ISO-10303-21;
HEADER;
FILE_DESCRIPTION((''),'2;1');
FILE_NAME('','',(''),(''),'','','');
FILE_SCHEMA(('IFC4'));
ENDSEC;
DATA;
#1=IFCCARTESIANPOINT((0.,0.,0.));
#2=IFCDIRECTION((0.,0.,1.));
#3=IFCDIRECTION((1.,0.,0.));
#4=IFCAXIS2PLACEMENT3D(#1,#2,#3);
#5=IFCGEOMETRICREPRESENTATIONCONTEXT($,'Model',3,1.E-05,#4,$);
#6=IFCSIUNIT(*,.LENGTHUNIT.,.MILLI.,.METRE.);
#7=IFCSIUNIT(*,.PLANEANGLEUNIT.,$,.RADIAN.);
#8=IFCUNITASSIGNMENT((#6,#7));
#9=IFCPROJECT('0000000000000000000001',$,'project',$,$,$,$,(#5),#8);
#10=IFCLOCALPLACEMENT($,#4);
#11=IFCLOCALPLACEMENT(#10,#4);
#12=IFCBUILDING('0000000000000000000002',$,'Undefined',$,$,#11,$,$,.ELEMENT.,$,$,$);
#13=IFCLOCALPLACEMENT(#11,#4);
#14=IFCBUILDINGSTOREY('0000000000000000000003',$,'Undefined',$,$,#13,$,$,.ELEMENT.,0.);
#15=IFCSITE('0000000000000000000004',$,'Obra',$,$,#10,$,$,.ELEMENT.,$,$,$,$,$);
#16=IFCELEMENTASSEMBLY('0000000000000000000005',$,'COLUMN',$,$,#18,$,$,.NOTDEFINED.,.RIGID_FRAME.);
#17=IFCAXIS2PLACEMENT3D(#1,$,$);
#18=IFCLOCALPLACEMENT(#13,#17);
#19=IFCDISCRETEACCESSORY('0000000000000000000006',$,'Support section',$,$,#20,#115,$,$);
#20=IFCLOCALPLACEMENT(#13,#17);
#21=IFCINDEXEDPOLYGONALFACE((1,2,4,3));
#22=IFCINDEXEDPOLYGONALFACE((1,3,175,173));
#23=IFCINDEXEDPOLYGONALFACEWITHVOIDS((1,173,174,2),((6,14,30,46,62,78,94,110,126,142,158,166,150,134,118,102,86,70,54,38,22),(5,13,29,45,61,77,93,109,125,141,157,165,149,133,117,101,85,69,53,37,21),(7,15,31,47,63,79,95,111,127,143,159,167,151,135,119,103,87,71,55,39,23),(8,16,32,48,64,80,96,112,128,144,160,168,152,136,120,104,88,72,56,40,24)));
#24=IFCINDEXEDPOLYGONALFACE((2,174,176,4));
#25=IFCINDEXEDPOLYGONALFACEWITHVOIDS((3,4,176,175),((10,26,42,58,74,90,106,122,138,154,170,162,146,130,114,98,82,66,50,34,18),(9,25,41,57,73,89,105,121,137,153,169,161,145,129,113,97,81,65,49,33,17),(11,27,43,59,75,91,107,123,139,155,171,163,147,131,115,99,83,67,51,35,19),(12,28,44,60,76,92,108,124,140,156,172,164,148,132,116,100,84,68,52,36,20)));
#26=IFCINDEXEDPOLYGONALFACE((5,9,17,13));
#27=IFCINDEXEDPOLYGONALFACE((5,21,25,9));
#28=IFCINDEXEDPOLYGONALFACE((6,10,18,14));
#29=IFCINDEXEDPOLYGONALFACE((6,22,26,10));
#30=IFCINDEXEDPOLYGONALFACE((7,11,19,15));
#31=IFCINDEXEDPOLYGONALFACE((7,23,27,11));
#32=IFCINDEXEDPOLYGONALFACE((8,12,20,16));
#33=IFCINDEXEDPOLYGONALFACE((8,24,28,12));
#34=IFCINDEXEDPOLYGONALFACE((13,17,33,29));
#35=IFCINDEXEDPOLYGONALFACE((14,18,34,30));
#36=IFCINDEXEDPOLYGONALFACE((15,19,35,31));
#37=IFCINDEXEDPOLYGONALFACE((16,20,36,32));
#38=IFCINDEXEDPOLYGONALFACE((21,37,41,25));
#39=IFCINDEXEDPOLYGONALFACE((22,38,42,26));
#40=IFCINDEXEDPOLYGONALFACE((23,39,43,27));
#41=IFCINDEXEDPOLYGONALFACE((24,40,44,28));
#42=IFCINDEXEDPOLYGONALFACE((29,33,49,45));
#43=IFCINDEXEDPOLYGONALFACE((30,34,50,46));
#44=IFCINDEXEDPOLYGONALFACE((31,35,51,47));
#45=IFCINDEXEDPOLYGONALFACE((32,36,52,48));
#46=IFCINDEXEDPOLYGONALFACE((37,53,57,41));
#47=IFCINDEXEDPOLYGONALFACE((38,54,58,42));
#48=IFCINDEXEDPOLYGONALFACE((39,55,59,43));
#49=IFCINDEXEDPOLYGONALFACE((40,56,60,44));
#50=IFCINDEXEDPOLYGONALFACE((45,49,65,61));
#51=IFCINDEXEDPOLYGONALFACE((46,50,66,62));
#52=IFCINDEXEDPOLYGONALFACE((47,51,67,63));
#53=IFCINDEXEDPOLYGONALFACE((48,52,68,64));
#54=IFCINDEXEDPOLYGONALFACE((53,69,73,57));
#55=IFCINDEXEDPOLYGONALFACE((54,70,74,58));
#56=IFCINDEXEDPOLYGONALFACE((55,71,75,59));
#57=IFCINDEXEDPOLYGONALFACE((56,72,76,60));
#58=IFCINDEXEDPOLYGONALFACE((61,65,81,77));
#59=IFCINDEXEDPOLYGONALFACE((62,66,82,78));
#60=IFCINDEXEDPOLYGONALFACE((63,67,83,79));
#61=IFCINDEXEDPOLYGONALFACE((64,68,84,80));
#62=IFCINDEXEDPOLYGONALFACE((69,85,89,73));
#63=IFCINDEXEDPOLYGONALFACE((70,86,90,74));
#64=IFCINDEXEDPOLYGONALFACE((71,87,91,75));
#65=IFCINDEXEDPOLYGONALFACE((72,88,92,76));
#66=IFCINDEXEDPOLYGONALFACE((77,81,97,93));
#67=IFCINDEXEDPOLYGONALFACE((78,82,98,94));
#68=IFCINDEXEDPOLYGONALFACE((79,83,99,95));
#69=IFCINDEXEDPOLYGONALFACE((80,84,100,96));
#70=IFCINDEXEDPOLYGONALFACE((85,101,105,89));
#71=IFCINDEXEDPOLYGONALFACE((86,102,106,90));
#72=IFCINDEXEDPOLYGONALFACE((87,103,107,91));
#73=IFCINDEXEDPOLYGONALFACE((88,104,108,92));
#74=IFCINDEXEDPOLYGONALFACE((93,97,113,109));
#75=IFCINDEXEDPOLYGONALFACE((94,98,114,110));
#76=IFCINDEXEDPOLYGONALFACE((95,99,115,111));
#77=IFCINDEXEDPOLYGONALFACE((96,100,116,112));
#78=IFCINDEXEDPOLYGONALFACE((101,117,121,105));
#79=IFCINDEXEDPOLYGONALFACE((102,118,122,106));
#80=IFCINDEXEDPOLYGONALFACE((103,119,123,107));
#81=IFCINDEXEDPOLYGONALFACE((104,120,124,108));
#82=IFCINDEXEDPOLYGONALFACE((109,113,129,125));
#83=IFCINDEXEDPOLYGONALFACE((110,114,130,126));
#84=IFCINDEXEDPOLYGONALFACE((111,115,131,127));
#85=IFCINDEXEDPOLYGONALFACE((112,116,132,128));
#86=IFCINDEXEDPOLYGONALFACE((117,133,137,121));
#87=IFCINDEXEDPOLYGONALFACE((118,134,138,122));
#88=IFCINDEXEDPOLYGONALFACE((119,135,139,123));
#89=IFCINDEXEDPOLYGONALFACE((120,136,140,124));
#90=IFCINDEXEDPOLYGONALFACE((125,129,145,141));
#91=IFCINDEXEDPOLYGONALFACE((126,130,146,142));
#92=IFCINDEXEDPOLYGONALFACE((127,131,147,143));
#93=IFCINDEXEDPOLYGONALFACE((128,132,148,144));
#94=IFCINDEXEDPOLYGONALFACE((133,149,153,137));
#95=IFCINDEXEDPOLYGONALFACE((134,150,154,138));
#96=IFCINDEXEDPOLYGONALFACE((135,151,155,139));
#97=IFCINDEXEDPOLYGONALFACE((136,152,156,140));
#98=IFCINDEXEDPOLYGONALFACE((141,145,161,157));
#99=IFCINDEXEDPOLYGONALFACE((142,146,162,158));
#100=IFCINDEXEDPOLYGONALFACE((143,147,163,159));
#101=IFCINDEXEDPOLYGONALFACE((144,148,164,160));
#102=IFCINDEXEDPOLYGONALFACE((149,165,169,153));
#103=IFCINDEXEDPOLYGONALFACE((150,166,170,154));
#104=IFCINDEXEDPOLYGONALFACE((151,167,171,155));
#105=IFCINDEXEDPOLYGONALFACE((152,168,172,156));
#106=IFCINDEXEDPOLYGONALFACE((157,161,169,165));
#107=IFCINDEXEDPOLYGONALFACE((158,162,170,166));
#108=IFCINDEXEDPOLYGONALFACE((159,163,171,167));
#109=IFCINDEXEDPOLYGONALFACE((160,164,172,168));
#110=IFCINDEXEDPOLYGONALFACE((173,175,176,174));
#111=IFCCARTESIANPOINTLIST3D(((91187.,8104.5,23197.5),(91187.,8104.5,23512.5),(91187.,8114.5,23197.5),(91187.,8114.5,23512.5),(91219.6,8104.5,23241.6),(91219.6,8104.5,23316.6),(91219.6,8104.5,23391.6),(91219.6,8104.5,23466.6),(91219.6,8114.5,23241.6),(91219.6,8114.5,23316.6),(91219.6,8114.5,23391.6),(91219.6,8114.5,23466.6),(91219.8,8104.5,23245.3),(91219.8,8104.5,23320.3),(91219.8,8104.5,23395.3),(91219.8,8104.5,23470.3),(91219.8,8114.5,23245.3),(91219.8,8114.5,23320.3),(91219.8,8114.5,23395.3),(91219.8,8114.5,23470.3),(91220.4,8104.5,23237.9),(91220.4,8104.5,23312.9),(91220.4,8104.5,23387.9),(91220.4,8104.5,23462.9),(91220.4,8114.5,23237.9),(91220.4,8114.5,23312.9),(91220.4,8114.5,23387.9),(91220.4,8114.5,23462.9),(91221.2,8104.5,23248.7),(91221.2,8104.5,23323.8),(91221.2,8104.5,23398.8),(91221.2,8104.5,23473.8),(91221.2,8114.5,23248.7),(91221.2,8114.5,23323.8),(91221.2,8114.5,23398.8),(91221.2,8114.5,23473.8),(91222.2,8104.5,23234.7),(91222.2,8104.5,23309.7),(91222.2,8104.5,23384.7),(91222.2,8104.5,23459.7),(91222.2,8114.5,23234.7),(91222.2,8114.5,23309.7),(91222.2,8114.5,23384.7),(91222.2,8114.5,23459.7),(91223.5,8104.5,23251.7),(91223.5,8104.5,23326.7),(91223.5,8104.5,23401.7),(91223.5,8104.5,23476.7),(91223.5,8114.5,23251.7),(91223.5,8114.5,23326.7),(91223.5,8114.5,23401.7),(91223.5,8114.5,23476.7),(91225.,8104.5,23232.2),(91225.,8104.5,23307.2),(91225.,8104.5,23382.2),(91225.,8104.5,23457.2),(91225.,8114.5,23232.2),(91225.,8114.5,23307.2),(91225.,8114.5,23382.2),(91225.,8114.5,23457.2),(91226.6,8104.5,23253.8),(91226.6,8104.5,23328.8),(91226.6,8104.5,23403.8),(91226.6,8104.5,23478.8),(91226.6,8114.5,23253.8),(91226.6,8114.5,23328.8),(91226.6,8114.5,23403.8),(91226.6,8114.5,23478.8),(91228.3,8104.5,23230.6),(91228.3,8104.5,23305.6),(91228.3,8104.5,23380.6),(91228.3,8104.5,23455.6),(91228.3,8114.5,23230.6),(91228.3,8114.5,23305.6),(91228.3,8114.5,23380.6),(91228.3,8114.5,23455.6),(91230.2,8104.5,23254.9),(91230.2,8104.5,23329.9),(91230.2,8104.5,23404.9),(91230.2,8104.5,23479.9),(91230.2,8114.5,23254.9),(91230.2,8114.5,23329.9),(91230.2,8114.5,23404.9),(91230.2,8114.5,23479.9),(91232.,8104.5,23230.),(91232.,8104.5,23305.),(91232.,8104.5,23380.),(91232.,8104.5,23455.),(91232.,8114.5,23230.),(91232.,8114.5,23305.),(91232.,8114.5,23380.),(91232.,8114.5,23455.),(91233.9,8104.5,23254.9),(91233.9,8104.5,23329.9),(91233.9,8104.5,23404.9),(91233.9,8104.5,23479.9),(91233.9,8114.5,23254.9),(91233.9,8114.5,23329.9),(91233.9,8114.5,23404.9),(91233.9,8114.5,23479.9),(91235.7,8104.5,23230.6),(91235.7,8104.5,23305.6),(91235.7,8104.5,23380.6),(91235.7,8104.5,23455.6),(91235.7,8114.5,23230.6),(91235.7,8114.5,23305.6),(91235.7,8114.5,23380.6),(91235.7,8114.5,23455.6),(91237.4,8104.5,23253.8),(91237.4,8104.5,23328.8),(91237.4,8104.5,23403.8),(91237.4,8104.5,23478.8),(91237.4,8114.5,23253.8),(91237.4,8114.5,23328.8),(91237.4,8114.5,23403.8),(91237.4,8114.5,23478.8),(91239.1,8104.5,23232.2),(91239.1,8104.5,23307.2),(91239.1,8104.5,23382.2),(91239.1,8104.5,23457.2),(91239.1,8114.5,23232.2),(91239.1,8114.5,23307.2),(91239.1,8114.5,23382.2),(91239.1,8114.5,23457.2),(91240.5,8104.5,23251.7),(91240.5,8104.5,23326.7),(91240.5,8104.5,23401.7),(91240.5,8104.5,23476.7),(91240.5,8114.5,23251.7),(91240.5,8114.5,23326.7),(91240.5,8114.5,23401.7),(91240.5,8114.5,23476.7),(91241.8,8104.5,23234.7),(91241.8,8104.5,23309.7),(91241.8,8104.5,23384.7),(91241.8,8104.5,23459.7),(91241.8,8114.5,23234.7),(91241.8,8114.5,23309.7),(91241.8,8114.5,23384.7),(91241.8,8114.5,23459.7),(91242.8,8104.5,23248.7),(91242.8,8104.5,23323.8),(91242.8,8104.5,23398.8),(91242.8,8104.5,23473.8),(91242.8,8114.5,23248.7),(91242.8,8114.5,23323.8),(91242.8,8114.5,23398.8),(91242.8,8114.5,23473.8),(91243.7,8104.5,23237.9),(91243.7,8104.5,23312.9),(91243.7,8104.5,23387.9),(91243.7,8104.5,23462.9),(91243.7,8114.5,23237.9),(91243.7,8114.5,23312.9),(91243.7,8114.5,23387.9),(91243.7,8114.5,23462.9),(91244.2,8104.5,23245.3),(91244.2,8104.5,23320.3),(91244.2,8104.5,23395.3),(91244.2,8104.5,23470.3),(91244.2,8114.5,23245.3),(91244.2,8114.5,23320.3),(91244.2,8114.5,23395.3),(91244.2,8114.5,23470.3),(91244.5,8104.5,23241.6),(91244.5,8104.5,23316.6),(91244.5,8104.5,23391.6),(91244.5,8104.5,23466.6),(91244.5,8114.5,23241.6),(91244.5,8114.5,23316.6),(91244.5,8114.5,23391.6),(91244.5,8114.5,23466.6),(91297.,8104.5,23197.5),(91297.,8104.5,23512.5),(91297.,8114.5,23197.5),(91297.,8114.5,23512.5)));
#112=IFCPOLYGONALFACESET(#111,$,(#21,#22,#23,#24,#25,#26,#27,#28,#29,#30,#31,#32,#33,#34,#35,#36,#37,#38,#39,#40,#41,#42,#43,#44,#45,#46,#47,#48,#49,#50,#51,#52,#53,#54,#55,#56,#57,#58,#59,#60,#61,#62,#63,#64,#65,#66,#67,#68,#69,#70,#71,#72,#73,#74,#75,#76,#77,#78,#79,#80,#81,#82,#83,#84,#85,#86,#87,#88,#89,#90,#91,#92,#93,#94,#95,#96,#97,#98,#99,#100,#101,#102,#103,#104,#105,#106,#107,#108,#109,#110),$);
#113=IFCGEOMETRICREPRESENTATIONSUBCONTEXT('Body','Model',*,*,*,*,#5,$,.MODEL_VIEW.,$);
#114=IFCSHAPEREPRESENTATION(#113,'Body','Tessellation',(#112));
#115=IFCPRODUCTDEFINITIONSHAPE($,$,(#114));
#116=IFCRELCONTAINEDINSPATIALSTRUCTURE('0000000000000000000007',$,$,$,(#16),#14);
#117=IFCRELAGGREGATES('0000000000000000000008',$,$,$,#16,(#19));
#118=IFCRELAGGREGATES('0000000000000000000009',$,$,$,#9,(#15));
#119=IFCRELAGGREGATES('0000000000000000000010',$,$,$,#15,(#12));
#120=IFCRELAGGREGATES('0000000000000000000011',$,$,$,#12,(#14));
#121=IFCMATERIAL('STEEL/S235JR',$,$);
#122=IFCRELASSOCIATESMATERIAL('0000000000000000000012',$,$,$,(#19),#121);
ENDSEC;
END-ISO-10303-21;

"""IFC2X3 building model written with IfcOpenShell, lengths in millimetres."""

from ifc_helpers import new_model, si_unit, frame, origin_with_axes, origin_2d_with_axis, place, context, subcontext, project, spatial, rectangle, circle, extrude, source, transform, mapped, material, element, aggregate, save


model = new_model("IFC2X3")

# Units and contexts
model_context = context("Model", 3, precision=1e-05, world=origin_with_axes())
body_context = subcontext(model_context, "Body", "Model", "MODEL_VIEW")
ifc_project = project(units=[si_unit("LENGTHUNIT", "METRE", prefix="MILLI"), si_unit("PLANEANGLEUNIT", "RADIAN")], contexts=[model_context])

# Site, building, storey
site_placement = place(None, origin_with_axes())
site = spatial("IfcSite", under=ifc_project, at=site_placement, Name="Obra", CompositionType="ELEMENT")
building_placement = place(site_placement, origin_with_axes())
building = spatial("IfcBuilding", under=site, at=building_placement, Name="Undefined", CompositionType="ELEMENT")
storey_placement = place(building_placement, origin_with_axes())
storey = spatial("IfcBuildingStorey", under=building, at=storey_placement, Name="Undefined", CompositionType="ELEMENT", Elevation=0.0)

# Shared definitions
ifc_material_1 = material(Name="STEEL/S235JR")

# Element assembly, discrete accessory, opening
assembly_1_placement = place(storey_placement, origin_with_axes())
assembly_1 = element("IfcElementAssembly", 1, at=assembly_1_placement, inside=storey, Name="COLUMN", AssemblyPlace="NOTDEFINED", PredefinedType="RIGID_FRAME")
discrete_accessory_1_placement = place(assembly_1_placement, frame((91242.0, 8109.5, 23197.5), z_axis=(0.0, 0.0, 1.0), x_axis=(1.0, 0.0, 0.0)))
discrete_accessory_1 = element("IfcDiscreteAccessory", 2, at=discrete_accessory_1_placement, material=ifc_material_1, Name="Support section", context=body_context, shape_type="SweptSolid", body=[
    extrude(rectangle(XDim=10.0, YDim=110.0, at=origin_2d_with_axis()), frame((0.0, 0.0, 315.0), z_axis=(0.0, 0.0, -1.0), x_axis=(0.0, 1.0, 0.0)), (0.0, 0.0, 1.0), 315.0),
])
shared_shape_1 = source(origin_with_axes(), body_context, "Body", "SweptSolid", [
    extrude(circle(Radius=12.5, at=origin_2d_with_axis()), frame((0.0, 5.7, 0.0), z_axis=(0.0, 1.0, 0.0), x_axis=(1.0, 0.0, 0.0)), (0.0, 0.0, 1.0), 10.2),
])
opening_1_placement = place(assembly_1_placement, frame((91277.0, 8120.2, 23575.0), z_axis=(-1.0, 0.0, 0.0), x_axis=(0.0, 0.0, -1.0)))
element("IfcOpeningElement", 3, at=opening_1_placement, cuts=discrete_accessory_1, ObjectType="Opening", context=body_context, shape_type="MappedRepresentation", body=[
    mapped(shared_shape_1, transform((107.5, 0.0, 45.0))),
    mapped(shared_shape_1, transform((182.5, 0.0, 45.0))),
    mapped(shared_shape_1, transform((257.5, 0.0, 45.0))),
    mapped(shared_shape_1, transform((332.5, 0.0, 45.0))),
])
aggregate(assembly_1, [discrete_accessory_1])

save(model, "model.ifc")
